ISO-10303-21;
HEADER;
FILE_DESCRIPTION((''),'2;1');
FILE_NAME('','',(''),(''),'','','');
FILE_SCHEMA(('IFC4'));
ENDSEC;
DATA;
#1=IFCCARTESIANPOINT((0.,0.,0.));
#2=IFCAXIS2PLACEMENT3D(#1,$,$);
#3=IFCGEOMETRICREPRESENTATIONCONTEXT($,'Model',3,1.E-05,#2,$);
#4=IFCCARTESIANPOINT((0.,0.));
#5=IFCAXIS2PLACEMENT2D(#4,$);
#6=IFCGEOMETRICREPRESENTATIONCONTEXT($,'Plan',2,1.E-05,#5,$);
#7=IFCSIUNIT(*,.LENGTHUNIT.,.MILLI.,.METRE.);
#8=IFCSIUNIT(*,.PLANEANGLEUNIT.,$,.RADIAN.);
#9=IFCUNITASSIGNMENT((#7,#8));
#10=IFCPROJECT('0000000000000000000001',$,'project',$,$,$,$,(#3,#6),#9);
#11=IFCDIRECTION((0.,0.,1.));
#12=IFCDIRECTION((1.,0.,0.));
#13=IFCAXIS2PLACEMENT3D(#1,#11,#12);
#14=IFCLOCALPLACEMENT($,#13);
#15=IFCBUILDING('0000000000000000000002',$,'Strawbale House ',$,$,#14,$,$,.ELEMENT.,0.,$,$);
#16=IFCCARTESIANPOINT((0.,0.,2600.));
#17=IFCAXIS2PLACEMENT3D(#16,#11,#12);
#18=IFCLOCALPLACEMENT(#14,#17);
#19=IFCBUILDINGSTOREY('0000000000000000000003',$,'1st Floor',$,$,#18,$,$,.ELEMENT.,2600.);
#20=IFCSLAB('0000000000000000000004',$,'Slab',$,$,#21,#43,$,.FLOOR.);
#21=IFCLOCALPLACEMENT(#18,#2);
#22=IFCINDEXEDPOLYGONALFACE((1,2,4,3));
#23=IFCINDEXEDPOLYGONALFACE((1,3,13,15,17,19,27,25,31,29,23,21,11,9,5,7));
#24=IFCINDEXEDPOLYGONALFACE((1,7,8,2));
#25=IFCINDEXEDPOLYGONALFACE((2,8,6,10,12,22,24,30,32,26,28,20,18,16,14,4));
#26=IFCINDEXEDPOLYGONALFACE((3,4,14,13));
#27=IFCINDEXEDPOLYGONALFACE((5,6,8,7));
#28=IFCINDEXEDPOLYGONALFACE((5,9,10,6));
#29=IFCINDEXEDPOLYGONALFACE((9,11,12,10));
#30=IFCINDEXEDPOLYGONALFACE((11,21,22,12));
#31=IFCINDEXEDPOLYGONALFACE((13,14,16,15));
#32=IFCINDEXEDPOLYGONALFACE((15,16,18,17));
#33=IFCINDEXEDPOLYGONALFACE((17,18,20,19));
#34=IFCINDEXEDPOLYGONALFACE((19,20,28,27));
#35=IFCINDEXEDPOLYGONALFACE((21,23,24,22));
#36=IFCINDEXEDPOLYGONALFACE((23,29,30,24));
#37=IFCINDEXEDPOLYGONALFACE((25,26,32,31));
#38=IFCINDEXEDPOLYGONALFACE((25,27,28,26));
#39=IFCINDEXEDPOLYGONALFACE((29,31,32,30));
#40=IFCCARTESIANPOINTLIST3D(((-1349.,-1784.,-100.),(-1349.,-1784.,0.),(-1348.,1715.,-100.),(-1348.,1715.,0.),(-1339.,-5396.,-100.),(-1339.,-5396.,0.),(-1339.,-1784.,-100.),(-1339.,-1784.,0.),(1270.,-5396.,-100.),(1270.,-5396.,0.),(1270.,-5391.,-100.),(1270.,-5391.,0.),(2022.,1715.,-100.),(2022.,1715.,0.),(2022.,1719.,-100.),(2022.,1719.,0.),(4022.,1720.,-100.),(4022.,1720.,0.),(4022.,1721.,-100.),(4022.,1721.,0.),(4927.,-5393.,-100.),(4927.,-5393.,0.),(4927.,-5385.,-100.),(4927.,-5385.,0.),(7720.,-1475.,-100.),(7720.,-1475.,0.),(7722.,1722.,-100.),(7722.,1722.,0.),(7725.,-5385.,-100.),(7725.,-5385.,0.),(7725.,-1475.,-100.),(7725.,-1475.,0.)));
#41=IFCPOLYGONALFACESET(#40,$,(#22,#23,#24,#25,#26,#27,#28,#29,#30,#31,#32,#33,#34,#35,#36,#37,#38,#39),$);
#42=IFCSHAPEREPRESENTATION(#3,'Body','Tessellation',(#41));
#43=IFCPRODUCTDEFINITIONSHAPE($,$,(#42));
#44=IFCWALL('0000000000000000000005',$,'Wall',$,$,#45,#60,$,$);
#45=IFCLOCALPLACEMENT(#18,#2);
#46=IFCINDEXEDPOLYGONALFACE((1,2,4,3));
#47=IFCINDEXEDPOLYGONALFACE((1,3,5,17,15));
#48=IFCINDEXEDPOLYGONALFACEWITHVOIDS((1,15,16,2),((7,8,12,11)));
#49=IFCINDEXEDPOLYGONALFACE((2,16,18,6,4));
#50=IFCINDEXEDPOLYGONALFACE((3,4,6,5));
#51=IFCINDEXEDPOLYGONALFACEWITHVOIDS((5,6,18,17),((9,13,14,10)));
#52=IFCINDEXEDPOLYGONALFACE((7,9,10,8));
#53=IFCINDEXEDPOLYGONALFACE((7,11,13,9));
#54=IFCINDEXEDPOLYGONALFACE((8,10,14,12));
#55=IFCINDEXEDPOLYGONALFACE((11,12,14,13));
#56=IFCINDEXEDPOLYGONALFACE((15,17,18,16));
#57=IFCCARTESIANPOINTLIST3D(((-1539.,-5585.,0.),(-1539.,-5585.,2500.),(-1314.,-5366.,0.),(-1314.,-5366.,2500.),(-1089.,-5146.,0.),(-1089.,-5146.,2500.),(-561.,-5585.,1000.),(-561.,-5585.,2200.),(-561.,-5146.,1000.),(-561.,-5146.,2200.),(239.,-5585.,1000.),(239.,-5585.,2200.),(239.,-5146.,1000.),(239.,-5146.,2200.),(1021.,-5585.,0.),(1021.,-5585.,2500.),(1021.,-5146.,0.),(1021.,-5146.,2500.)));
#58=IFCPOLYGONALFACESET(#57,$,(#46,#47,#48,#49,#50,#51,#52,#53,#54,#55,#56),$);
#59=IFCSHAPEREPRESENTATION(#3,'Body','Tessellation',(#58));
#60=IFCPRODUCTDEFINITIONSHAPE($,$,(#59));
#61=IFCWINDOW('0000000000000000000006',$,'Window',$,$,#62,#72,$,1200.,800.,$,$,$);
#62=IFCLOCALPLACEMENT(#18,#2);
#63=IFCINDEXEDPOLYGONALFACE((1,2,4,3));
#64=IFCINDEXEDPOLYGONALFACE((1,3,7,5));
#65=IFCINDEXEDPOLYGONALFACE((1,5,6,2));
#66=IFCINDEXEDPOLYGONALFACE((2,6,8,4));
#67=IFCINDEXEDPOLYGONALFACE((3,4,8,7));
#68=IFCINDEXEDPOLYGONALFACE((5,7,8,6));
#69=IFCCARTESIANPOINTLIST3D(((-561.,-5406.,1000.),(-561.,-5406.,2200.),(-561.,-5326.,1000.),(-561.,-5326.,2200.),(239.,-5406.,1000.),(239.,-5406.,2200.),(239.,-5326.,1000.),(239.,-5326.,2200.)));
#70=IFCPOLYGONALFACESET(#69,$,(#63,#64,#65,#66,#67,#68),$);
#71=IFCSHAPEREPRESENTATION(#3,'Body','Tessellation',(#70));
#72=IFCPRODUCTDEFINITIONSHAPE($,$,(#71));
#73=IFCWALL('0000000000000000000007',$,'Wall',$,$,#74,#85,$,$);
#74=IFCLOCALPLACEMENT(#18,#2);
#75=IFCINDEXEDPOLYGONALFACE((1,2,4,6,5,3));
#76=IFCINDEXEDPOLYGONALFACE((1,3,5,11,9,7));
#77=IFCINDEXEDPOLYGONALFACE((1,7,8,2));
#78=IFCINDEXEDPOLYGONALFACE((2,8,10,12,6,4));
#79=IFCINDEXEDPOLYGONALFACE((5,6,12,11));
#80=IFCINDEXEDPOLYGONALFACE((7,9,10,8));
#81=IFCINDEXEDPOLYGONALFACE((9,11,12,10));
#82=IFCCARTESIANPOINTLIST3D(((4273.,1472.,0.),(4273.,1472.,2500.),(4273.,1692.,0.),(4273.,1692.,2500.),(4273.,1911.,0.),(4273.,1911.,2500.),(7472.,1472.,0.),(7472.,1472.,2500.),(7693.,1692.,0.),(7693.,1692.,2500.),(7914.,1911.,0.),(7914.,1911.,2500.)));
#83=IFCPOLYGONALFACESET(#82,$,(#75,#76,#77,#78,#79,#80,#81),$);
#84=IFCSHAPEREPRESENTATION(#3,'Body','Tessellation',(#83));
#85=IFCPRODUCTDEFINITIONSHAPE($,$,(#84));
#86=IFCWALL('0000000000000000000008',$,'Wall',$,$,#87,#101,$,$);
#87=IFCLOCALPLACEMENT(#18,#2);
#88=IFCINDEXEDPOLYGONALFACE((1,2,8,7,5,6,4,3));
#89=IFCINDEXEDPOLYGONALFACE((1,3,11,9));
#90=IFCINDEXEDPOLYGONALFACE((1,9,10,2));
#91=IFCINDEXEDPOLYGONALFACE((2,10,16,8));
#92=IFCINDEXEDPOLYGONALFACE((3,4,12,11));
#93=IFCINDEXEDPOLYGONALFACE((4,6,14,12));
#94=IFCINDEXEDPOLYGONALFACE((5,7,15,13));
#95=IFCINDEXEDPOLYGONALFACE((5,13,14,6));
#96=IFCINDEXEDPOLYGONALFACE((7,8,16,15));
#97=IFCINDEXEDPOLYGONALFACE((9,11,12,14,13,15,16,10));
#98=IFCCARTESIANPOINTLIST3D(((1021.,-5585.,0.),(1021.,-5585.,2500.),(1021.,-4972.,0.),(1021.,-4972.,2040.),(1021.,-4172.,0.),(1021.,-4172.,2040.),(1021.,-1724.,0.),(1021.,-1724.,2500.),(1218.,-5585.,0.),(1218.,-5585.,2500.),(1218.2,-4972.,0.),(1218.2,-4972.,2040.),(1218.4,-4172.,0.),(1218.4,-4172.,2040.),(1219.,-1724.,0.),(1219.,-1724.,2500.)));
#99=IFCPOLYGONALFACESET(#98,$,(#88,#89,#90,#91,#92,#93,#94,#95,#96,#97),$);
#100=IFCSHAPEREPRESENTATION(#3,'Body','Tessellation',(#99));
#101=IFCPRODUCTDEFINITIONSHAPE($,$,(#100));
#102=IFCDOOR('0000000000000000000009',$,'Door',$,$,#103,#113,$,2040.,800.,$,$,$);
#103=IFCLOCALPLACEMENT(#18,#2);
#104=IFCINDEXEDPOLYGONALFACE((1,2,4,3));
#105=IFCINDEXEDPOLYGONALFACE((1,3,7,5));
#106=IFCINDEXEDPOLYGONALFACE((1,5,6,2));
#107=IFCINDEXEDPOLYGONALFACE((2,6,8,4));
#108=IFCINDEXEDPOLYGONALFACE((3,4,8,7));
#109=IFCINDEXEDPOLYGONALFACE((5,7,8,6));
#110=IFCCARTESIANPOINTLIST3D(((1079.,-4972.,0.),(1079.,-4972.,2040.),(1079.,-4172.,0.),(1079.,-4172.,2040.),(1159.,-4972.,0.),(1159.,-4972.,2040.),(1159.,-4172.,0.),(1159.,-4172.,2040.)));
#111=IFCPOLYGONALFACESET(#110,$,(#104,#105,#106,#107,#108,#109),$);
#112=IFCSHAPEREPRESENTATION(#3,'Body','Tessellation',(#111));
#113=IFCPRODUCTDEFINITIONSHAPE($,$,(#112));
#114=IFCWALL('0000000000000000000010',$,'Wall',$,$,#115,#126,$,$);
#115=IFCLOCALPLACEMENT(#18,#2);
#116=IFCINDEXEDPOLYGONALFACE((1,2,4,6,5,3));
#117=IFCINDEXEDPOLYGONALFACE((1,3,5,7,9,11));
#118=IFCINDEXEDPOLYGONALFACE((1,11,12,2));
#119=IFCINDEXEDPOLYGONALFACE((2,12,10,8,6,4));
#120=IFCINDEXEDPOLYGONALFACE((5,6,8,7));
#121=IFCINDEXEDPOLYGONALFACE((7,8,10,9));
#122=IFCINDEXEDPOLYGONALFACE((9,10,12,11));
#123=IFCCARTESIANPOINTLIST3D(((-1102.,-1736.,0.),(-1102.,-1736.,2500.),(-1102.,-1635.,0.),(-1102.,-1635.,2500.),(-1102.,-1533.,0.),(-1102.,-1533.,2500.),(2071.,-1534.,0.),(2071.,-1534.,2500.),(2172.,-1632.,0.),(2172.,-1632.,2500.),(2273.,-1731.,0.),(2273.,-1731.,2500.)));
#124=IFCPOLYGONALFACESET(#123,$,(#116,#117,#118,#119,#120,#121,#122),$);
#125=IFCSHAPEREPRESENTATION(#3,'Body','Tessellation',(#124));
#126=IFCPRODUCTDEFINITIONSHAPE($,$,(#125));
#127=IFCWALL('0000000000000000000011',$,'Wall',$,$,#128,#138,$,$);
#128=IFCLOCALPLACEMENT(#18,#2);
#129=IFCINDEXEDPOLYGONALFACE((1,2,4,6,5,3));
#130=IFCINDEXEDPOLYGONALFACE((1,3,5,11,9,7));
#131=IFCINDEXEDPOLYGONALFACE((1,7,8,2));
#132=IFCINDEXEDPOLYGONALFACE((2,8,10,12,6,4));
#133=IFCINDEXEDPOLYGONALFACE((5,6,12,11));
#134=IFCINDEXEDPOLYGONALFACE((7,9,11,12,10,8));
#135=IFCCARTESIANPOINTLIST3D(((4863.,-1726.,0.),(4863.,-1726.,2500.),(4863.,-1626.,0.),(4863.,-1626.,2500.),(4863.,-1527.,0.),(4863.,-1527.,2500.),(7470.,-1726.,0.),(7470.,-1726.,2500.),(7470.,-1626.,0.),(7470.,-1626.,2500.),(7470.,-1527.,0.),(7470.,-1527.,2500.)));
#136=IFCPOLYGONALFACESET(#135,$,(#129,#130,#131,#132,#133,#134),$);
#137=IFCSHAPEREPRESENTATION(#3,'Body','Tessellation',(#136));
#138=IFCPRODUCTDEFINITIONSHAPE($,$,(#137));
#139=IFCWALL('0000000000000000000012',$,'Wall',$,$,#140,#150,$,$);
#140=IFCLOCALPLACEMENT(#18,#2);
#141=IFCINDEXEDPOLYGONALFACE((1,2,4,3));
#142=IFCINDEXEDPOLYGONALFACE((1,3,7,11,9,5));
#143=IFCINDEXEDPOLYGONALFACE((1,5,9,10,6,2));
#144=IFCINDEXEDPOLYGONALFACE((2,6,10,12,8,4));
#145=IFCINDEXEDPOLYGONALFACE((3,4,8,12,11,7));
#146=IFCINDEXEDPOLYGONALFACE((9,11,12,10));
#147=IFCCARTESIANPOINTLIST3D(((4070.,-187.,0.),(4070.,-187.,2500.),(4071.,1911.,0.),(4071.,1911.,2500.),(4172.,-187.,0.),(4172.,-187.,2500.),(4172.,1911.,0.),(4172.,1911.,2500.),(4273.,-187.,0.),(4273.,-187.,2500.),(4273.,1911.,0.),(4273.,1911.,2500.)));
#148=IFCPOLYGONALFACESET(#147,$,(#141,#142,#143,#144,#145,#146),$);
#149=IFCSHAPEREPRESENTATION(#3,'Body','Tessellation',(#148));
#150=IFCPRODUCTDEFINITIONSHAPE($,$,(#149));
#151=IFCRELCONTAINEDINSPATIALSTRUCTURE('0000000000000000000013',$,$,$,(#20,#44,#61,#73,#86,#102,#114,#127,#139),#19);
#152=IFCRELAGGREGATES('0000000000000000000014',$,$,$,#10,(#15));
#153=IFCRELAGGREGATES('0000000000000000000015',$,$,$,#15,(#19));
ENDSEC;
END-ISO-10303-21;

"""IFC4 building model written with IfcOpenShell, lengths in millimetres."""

from ifc_helpers import new_model, si_unit, frame, origin, origin_with_axes, origin_2d, origin_2d_with_axis, place, context, project, spatial, polyline, rectangle, outline, extrude, element, fill, save


model = new_model("IFC4")

# Units and contexts
model_context = context("Model", 3, precision=1e-05, world=origin())
plan_context = context("Plan", 2, precision=1e-05, world=origin_2d())
ifc_project = project(units=[si_unit("LENGTHUNIT", "METRE", prefix="MILLI"), si_unit("PLANEANGLEUNIT", "RADIAN")], contexts=[model_context, plan_context])

# Building, storey
building_placement = place(None, origin_with_axes())
building = spatial("IfcBuilding", under=ifc_project, at=building_placement, Name="Strawbale House ", CompositionType="ELEMENT", ElevationOfRefHeight=0.0)
storey_placement = place(building_placement, frame((0.0, 0.0, 2600.0), z_axis=(0.0, 0.0, 1.0), x_axis=(1.0, 0.0, 0.0)))
storey = spatial("IfcBuildingStorey", under=building, at=storey_placement, Name="1st Floor", CompositionType="ELEMENT", Elevation=2600.0)

# Slab
slab_placement = place(storey_placement, origin_with_axes())
element("IfcSlab", 1, at=slab_placement, inside=storey, Name="Slab", PredefinedType="FLOOR", context=model_context, shape_type="SweptSolid", body=[
    extrude(outline(polyline([(1270.0, -5391.0, 0.0), (4927.0, -5393.0, 0.0), (4927.0, -5385.0, 0.0), (7725.0, -5385.0, 0.0), (7725.0, -1475.0, 0.0), (7720.0, -1475.0, 0.0), (7722.0, 1722.0, 0.0), (4022.0, 1721.0, 0.0), (4022.0, 1720.0, 0.0), (2022.0, 1719.0, 0.0), (2022.0, 1715.0, 0.0), (-1348.0, 1715.0, 0.0), (-1349.0, -1784.0, 0.0), (-1339.0, -1784.0, 0.0), (-1339.0, -5396.0, 0.0), (1270.0, -5396.0, 0.0), (1270.0, -5391.0, 0.0)])), origin_with_axes(), (0.0, 0.0, -1.0), 100.0),
])

# Wall, opening, window
wall_1_placement = place(storey_placement, origin_with_axes())
wall_1 = element("IfcWall", 2, at=wall_1_placement, inside=storey, Name="Wall", context=model_context, shape_type="SweptSolid", body=[
    extrude(outline(polyline([(-1314.0, -5366.0, 0.0), (-1089.0, -5146.0, 0.0), (1021.0, -5146.0, 0.0), (1021.0, -5366.0, 0.0), (1021.0, -5585.0, 0.0), (-1539.0, -5585.0, 0.0), (-1314.0, -5366.0, 0.0)])), origin_with_axes(), (0.0, 0.0, 1.0), 2500.0),
])
opening_1_placement = place(wall_1_placement, frame((-161.0, -5046.0, 1600.0), z_axis=(0.0, 0.0, 1.0), x_axis=(1.0, 0.0, 0.0)))
opening_1 = element("IfcOpeningElement", 3, at=opening_1_placement, cuts=wall_1, PredefinedType="OPENING", context=model_context, shape_type="SweptSolid", body=[
    extrude(rectangle(XDim=800.0, YDim=1200.0, at=origin_2d_with_axis()), frame((0.0, 0.0, 0.0), z_axis=(0.0, -2110.0, 0.0), x_axis=(2110.0, 0.0, 0.0)), (0.0, 0.0, 1.0), 639.0),
])
window_1_placement = place(opening_1_placement, frame((0.0, -280.0, 0.0), z_axis=(0.0, 0.0, 1.0), x_axis=(1.0, 0.0, 0.0)))
window_1 = element("IfcWindow", 4, at=window_1_placement, inside=storey, Name="Window", OverallHeight=1200.0, OverallWidth=800.0, context=model_context, shape_type="SweptSolid", body=[
    extrude(outline(polyline([(400.0, 600.0, 0.0), (400.0, -600.0, 0.0), (-400.0, -600.0, 0.0), (-400.0, 600.0, 0.0), (400.0, 600.0, 0.0)])), frame((0.0, 0.0, 0.0), z_axis=(0.0, -2110.0, 0.0), x_axis=(2110.0, 0.0, 0.0)), (0.0, 0.0, 1.0), 80.0),
])
fill(opening_1, window_1)

# Wall
wall_2_placement = place(storey_placement, origin_with_axes())
element("IfcWall", 5, at=wall_2_placement, inside=storey, Name="Wall", context=model_context, shape_type="SweptSolid", body=[
    extrude(outline(polyline([(7693.0, 1692.0, 0.0), (7472.0, 1472.0, 0.0), (4273.0, 1472.0, 0.0), (4273.0, 1692.0, 0.0), (4273.0, 1911.0, 0.0), (7914.0, 1911.0, 0.0), (7693.0, 1692.0, 0.0)])), origin_with_axes(), (0.0, 0.0, 1.0), 2500.0),
])

# Wall, opening, door
wall_3_placement = place(storey_placement, origin_with_axes())
wall_3 = element("IfcWall", 6, at=wall_3_placement, inside=storey, Name="Wall", context=model_context, shape_type="SweptSolid", body=[
    extrude(outline(polyline([(1119.0, -5585.0, 0.0), (1021.0, -5585.0, 0.0), (1021.0, -1724.0, 0.0), (1120.0, -1724.0, 0.0), (1219.0, -1724.0, 0.0), (1218.0, -5585.0, 0.0), (1119.0, -5585.0, 0.0)])), origin_with_axes(), (0.0, 0.0, 1.0), 2500.0),
])
opening_2_placement = place(wall_3_placement, frame((921.0, -4572.0, 1020.0), z_axis=(0.0, 0.0, 1.0), x_axis=(1.0, 0.0, 0.0)))
opening_2 = element("IfcOpeningElement", 7, at=opening_2_placement, cuts=wall_3, PredefinedType="OPENING", context=model_context, shape_type="SweptSolid", body=[
    extrude(rectangle(XDim=800.0, YDim=2040.0, at=origin_2d_with_axis()), frame((0.0, 0.0, 0.0), z_axis=(3860.991, 0.0, 0.0), x_axis=(0.0, 3860.991, 0.0)), (0.0, 0.0, 1.0), 396.9),
])
door_1_placement = place(opening_2_placement, frame((158.0, 0.0, 0.0), z_axis=(0.0, 0.0, 1.0), x_axis=(1.0, 0.0, 0.0)))
door_1 = element("IfcDoor", 8, at=door_1_placement, inside=storey, Name="Door", OverallHeight=2040.0, OverallWidth=800.0, context=model_context, shape_type="SweptSolid", body=[
    extrude(outline(polyline([(400.0, 1020.0, 0.0), (400.0, -1020.0, 0.0), (-400.0, -1020.0, 0.0), (-400.0, 1020.0, 0.0), (400.0, 1020.0, 0.0)])), frame((0.0, 0.0, 0.0), z_axis=(3860.991, 0.0, 0.0), x_axis=(0.0, 3860.991, 0.0)), (0.0, 0.0, 1.0), 80.0),
])
fill(opening_2, door_1)

# Wall
wall_4_placement = place(storey_placement, origin_with_axes())
element("IfcWall", 9, at=wall_4_placement, inside=storey, Name="Wall", context=model_context, shape_type="SweptSolid", body=[
    extrude(outline(polyline([(2172.0, -1632.0, 0.0), (2273.0, -1731.0, 0.0), (-1102.0, -1736.0, 0.0), (-1102.0, -1635.0, 0.0), (-1102.0, -1533.0, 0.0), (2071.0, -1534.0, 0.0), (2172.0, -1632.0, 0.0)])), origin_with_axes(), (0.0, 0.0, 1.0), 2500.0),
])

# Wall
wall_5_placement = place(storey_placement, origin_with_axes())
element("IfcWall", 10, at=wall_5_placement, inside=storey, Name="Wall", context=model_context, shape_type="SweptSolid", body=[
    extrude(outline(polyline([(7470.0, -1626.0, 0.0), (7470.0, -1726.0, 0.0), (4863.0, -1726.0, 0.0), (4863.0, -1626.0, 0.0), (4863.0, -1527.0, 0.0), (7470.0, -1527.0, 0.0), (7470.0, -1626.0, 0.0)])), origin_with_axes(), (0.0, 0.0, 1.0), 2500.0),
])

# Wall
wall_6_placement = place(storey_placement, origin_with_axes())
element("IfcWall", 11, at=wall_6_placement, inside=storey, Name="Wall", context=model_context, shape_type="SweptSolid", body=[
    extrude(outline(polyline([(4172.0, 1911.0, 0.0), (4273.0, 1911.0, 0.0), (4273.0, -187.0, 0.0), (4172.0, -187.0, 0.0), (4070.0, -187.0, 0.0), (4071.0, 1911.0, 0.0), (4172.0, 1911.0, 0.0)])), origin_with_axes(), (0.0, 0.0, 1.0), 2500.0),
])

save(model, "model.ifc")
